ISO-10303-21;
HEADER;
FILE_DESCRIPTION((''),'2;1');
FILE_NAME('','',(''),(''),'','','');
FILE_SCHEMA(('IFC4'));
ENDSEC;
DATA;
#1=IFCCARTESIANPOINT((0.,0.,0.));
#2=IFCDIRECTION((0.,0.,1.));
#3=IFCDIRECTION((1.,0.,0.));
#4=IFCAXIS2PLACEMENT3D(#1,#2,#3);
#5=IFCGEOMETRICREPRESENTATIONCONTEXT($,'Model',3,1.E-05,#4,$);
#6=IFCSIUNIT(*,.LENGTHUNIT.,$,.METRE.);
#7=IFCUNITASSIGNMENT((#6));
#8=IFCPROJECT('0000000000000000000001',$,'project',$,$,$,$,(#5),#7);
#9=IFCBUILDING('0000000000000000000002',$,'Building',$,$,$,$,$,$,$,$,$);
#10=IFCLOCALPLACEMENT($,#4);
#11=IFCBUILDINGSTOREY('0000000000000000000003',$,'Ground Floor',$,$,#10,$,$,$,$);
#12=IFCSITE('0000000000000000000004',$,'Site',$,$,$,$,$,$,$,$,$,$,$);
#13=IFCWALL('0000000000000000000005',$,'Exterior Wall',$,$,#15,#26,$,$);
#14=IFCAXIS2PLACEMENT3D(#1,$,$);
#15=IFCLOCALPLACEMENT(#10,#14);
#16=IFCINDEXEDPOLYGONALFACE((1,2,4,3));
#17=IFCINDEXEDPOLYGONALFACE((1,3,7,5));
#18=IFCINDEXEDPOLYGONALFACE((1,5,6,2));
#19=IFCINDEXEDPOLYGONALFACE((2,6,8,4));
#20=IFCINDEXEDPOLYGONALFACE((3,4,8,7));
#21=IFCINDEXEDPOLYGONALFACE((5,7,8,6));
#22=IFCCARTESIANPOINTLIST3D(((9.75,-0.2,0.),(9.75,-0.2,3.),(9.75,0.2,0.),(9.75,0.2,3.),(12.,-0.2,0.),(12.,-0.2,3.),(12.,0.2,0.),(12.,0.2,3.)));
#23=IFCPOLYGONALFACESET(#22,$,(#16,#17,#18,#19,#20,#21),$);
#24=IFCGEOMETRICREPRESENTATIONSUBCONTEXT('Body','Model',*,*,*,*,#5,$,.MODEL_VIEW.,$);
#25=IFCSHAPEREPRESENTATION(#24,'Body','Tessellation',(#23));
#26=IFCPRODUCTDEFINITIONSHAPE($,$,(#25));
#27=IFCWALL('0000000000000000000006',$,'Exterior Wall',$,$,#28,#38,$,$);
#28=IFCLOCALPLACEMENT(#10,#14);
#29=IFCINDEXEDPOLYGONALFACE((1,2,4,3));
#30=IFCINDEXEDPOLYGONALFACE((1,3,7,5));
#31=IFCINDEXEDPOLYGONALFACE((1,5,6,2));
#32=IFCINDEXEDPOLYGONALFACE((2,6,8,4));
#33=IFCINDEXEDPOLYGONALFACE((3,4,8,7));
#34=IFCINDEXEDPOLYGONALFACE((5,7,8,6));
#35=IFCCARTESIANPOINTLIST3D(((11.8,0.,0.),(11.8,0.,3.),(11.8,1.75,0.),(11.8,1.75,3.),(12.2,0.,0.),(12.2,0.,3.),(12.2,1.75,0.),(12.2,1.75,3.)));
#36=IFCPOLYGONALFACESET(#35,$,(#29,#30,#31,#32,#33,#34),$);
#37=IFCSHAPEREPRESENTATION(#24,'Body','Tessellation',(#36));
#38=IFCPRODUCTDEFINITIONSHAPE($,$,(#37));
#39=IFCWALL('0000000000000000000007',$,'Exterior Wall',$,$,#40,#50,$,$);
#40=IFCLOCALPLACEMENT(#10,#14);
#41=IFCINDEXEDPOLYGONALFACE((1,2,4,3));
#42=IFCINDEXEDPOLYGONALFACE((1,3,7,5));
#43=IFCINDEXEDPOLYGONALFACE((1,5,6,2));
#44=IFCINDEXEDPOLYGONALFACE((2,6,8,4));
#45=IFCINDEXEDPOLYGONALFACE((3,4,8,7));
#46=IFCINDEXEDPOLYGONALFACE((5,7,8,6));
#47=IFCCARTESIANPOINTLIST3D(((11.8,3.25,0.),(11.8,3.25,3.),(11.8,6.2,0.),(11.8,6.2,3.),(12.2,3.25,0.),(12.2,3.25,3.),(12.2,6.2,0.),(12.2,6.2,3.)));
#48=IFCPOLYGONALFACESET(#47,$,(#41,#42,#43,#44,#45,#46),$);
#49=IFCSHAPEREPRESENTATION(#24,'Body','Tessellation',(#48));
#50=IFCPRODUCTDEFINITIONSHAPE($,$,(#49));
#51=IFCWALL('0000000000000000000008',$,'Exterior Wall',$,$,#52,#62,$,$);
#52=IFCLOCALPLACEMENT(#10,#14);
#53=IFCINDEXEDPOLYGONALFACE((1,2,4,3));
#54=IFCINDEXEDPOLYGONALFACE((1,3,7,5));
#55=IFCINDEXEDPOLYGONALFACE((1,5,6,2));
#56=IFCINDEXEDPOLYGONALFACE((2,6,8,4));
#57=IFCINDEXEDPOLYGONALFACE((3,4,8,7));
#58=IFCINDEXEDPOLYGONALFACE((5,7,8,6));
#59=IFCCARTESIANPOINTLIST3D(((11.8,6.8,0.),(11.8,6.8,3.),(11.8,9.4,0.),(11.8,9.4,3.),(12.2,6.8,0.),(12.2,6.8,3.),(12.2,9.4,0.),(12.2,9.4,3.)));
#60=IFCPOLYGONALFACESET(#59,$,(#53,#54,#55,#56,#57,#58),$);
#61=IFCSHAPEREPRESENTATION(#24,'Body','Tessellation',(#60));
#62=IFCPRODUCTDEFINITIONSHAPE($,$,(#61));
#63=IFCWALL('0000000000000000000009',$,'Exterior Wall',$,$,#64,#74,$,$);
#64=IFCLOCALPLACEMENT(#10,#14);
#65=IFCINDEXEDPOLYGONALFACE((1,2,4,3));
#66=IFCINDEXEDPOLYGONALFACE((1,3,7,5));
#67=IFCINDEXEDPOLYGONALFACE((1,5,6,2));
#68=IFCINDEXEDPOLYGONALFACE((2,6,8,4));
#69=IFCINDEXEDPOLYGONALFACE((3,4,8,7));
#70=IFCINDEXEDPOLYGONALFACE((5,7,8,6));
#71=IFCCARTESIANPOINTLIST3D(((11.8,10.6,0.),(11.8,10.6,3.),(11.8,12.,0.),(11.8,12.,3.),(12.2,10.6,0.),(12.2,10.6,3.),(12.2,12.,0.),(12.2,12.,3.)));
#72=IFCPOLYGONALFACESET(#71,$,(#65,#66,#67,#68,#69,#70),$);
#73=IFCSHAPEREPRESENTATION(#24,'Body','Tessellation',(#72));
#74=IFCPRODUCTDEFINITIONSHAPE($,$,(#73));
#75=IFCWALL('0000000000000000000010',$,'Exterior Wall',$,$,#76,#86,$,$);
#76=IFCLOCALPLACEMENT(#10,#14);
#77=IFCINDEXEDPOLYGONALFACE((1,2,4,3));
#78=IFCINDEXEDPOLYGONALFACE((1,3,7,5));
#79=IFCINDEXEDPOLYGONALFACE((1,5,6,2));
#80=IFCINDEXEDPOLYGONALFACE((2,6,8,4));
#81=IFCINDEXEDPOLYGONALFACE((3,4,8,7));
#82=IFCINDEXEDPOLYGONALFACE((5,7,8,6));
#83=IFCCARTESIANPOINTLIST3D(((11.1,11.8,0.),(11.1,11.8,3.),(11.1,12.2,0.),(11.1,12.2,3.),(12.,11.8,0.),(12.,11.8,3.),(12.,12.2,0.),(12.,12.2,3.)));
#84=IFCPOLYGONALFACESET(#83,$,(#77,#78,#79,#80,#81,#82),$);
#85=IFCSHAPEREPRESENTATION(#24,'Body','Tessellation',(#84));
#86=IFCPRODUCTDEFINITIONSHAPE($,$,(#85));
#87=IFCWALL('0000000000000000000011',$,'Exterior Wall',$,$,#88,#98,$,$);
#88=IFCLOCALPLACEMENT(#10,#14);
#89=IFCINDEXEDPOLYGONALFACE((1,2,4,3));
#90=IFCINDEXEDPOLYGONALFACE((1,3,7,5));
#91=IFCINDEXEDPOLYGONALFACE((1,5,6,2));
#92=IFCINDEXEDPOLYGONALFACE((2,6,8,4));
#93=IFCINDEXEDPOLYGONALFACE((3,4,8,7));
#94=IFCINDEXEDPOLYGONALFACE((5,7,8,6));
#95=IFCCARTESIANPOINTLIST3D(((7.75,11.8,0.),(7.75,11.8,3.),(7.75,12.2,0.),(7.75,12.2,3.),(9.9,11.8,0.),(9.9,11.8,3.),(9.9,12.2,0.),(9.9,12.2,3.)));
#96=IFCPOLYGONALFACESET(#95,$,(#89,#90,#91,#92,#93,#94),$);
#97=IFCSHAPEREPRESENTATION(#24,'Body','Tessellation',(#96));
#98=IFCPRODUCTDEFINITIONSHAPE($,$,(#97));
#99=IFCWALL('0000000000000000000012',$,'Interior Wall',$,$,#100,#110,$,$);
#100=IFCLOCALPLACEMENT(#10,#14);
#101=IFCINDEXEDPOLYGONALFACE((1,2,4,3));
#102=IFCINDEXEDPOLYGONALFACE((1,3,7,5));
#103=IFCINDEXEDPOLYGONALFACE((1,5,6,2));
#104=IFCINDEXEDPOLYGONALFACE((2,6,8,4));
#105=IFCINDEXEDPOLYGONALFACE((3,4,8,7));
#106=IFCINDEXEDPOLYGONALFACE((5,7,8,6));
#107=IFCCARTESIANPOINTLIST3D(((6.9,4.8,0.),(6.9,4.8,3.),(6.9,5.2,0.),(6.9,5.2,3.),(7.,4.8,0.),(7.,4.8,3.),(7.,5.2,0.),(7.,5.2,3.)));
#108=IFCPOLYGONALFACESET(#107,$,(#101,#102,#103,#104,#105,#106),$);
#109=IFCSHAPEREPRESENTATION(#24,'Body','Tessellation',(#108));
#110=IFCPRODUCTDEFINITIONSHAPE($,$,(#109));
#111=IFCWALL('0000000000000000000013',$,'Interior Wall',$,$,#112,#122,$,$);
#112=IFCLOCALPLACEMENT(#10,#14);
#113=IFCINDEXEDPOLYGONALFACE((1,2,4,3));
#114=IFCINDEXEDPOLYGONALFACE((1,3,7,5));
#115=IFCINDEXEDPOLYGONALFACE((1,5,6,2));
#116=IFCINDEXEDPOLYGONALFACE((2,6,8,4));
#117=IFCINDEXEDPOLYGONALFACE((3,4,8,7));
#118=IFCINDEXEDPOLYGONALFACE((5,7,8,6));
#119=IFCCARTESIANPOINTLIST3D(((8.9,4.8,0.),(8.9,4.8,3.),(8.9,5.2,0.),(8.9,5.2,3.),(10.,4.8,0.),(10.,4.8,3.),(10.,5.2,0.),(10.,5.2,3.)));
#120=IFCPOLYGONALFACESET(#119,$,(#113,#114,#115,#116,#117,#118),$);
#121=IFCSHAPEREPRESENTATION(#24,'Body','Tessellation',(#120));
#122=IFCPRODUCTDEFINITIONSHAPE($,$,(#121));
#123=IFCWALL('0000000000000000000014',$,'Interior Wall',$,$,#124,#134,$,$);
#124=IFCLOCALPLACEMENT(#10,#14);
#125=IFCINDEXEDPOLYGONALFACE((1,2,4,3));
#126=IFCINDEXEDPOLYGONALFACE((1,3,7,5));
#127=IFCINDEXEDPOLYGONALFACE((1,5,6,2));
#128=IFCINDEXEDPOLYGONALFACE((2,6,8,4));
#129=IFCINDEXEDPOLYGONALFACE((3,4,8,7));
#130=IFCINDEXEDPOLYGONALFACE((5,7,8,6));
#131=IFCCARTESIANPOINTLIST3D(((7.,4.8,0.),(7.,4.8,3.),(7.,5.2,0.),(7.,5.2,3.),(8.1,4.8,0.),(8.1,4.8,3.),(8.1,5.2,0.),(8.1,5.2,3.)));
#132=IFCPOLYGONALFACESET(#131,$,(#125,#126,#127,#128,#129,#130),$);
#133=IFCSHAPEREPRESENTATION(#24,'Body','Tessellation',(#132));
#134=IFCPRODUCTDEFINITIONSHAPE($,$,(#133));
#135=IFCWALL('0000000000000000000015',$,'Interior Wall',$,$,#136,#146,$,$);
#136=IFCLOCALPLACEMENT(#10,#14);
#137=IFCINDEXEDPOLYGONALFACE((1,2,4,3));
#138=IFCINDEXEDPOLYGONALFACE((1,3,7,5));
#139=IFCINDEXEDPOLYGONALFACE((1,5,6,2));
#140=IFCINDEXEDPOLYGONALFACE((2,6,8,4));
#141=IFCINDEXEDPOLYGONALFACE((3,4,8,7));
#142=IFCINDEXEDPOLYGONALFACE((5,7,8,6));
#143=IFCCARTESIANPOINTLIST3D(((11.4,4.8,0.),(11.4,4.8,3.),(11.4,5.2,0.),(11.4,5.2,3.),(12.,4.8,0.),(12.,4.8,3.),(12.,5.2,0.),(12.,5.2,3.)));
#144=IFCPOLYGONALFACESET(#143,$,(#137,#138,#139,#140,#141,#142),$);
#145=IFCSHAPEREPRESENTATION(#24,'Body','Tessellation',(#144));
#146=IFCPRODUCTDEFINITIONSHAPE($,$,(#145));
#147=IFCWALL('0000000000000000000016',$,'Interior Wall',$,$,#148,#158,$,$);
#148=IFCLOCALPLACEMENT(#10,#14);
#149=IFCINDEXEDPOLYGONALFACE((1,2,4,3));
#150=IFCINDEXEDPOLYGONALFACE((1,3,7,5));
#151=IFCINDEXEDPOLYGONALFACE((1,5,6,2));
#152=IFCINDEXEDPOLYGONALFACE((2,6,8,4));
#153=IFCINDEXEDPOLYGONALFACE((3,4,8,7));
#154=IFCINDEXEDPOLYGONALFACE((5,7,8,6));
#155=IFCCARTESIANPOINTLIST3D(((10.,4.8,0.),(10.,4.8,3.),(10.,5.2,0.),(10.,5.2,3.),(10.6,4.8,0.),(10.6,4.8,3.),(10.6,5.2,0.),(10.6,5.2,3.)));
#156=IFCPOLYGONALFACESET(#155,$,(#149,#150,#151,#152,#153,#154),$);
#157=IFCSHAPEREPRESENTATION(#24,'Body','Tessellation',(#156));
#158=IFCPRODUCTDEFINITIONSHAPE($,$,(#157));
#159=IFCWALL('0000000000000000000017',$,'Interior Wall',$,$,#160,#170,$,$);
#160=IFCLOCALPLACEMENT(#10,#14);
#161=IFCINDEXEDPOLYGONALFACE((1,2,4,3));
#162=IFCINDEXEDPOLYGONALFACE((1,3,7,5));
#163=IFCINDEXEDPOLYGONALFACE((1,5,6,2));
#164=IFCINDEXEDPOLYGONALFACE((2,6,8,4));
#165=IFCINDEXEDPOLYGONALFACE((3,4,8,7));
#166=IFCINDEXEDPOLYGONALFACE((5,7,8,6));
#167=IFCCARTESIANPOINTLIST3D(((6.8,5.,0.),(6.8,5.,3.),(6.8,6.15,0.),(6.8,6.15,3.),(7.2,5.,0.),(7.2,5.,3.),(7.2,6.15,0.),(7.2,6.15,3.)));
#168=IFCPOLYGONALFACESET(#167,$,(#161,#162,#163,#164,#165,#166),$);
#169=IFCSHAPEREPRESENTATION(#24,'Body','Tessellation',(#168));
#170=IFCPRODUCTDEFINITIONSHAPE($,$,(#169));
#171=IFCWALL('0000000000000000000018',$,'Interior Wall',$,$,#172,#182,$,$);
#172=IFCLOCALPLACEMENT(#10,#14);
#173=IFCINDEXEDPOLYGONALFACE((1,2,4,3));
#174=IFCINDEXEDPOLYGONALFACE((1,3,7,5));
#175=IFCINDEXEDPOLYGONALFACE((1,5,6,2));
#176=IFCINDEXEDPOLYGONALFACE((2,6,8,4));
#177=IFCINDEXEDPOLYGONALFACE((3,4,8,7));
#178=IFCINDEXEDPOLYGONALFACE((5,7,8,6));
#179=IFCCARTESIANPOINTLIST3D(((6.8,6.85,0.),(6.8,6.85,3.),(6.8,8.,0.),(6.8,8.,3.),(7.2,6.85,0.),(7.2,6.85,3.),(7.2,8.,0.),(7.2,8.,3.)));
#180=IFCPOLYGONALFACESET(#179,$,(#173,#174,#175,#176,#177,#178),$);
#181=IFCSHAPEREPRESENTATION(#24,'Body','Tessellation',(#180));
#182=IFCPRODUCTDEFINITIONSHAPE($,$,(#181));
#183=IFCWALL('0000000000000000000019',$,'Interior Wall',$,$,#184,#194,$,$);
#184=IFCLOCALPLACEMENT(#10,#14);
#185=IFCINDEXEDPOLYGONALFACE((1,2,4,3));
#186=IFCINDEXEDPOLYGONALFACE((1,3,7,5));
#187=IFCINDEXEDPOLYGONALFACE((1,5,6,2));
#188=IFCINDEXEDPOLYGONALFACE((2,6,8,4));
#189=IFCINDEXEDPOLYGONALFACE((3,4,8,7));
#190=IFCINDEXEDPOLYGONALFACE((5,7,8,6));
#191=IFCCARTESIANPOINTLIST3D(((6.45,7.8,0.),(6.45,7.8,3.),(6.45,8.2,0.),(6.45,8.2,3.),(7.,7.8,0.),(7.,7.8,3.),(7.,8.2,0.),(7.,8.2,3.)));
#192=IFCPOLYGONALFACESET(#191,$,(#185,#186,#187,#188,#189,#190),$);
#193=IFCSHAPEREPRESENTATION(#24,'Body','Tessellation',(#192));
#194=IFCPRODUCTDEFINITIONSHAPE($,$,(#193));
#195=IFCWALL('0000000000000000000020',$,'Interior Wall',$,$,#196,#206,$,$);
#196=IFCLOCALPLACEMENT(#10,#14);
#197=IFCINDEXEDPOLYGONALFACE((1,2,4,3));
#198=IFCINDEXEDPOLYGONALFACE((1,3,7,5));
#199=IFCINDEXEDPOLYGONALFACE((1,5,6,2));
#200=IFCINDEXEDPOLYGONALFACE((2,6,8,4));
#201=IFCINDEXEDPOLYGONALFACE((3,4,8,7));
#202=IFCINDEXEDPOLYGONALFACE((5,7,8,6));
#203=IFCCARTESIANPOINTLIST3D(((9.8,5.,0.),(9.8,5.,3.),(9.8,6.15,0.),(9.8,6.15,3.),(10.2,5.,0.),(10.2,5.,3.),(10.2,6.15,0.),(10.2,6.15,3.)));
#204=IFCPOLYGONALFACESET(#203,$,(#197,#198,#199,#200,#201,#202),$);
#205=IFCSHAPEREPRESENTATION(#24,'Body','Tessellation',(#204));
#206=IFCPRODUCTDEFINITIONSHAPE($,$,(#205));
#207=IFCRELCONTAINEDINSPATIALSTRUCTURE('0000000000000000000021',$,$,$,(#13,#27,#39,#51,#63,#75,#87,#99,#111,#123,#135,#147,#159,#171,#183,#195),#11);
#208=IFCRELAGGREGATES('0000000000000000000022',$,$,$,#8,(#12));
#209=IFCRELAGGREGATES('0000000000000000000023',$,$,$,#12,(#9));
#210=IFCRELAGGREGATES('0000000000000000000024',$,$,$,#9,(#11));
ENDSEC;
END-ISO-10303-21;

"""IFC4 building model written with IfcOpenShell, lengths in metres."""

from ifc_helpers import new_model, si_unit, frame, origin_with_axes, place, context, subcontext, project, spatial, indexed_curve, outline, extrude, element, save


model = new_model("IFC4")

# Units and contexts
model_context = context("Model", 3, precision=1e-05, world=origin_with_axes())
body_context = subcontext(model_context, "Body", "Model", "MODEL_VIEW")
ifc_project = project(units=[si_unit("LENGTHUNIT", "METRE")], contexts=[model_context])

# Site, building, storey
site = spatial("IfcSite", under=ifc_project, Name="Site")
building = spatial("IfcBuilding", under=site, Name="Building")
storey_placement = place(None, origin_with_axes())
storey = spatial("IfcBuildingStorey", under=building, at=storey_placement, Name="Ground Floor")

# Walls
wall_1_placement = place(storey_placement, frame((9.75, 0.0, 0.0), z_axis=(0.0, 0.0, 1.0), x_axis=(1.0, 0.0, 0.0)))
element("IfcWall", 1, at=wall_1_placement, inside=storey, Name="Exterior Wall", context=body_context, shape_type="SweptSolid", body=[
    extrude(outline(indexed_curve([(0.0, 0.0), (0.0, 0.4), (2.25, 0.4), (2.25, 0.0), (0.0, 0.0)], self_intersect=False)), frame((0.0, -0.2, 0.0), z_axis=(0.0, 0.0, 1.0), x_axis=(1.0, 0.0, 0.0)), (0.0, 0.0, 1.0), 3.0),
])
wall_2_placement = place(storey_placement, frame((12.0, 0.0, 0.0), z_axis=(0.0, 0.0, 1.0), x_axis=(0.0, 1.0, 0.0)))
element("IfcWall", 2, at=wall_2_placement, inside=storey, Name="Exterior Wall", context=body_context, shape_type="SweptSolid", body=[
    extrude(outline(indexed_curve([(0.0, 0.0), (0.0, 0.4), (1.75, 0.4), (1.75, 0.0), (0.0, 0.0)], self_intersect=False)), frame((0.0, -0.2, 0.0), z_axis=(0.0, 0.0, 1.0), x_axis=(1.0, 0.0, 0.0)), (0.0, 0.0, 1.0), 3.0),
])
wall_3_placement = place(storey_placement, frame((12.0, 3.25, 0.0), z_axis=(0.0, 0.0, 1.0), x_axis=(0.0, 1.0, 0.0)))
element("IfcWall", 3, at=wall_3_placement, inside=storey, Name="Exterior Wall", context=body_context, shape_type="SweptSolid", body=[
    extrude(outline(indexed_curve([(0.0, 0.0), (0.0, 0.4), (2.95, 0.4), (2.95, 0.0), (0.0, 0.0)], self_intersect=False)), frame((0.0, -0.2, 0.0), z_axis=(0.0, 0.0, 1.0), x_axis=(1.0, 0.0, 0.0)), (0.0, 0.0, 1.0), 3.0),
])
wall_4_placement = place(storey_placement, frame((12.0, 6.8, 0.0), z_axis=(0.0, 0.0, 1.0), x_axis=(0.0, 1.0, 0.0)))
element("IfcWall", 4, at=wall_4_placement, inside=storey, Name="Exterior Wall", context=body_context, shape_type="SweptSolid", body=[
    extrude(outline(indexed_curve([(0.0, 0.0), (0.0, 0.4), (2.6, 0.4), (2.6, 0.0), (0.0, 0.0)], self_intersect=False)), frame((0.0, -0.2, 0.0), z_axis=(0.0, 0.0, 1.0), x_axis=(1.0, 0.0, 0.0)), (0.0, 0.0, 1.0), 3.0),
])
wall_5_placement = place(storey_placement, frame((12.0, 10.6, 0.0), z_axis=(0.0, 0.0, 1.0), x_axis=(0.0, 1.0, 0.0)))
element("IfcWall", 5, at=wall_5_placement, inside=storey, Name="Exterior Wall", context=body_context, shape_type="SweptSolid", body=[
    extrude(outline(indexed_curve([(0.0, 0.0), (0.0, 0.4), (1.4, 0.4), (1.4, 0.0), (0.0, 0.0)], self_intersect=False)), frame((0.0, -0.2, 0.0), z_axis=(0.0, 0.0, 1.0), x_axis=(1.0, 0.0, 0.0)), (0.0, 0.0, 1.0), 3.0),
])
wall_6_placement = place(storey_placement, frame((12.0, 12.0, 0.0), z_axis=(0.0, 0.0, 1.0), x_axis=(-1.0, 0.0, 0.0)))
element("IfcWall", 6, at=wall_6_placement, inside=storey, Name="Exterior Wall", context=body_context, shape_type="SweptSolid", body=[
    extrude(outline(indexed_curve([(0.0, 0.0), (0.0, 0.4), (0.9, 0.4), (0.9, 0.0), (0.0, 0.0)], self_intersect=False)), frame((0.0, -0.2, 0.0), z_axis=(0.0, 0.0, 1.0), x_axis=(1.0, 0.0, 0.0)), (0.0, 0.0, 1.0), 3.0),
])
wall_7_placement = place(storey_placement, frame((9.9, 12.0, 0.0), z_axis=(0.0, 0.0, 1.0), x_axis=(-1.0, 0.0, 0.0)))
element("IfcWall", 7, at=wall_7_placement, inside=storey, Name="Exterior Wall", context=body_context, shape_type="SweptSolid", body=[
    extrude(outline(indexed_curve([(0.0, 0.0), (0.0, 0.4), (2.15, 0.4), (2.15, 0.0), (0.0, 0.0)], self_intersect=False)), frame((0.0, -0.2, 0.0), z_axis=(0.0, 0.0, 1.0), x_axis=(1.0, 0.0, 0.0)), (0.0, 0.0, 1.0), 3.0),
])
wall_8_placement = place(storey_placement, frame((7.0, 5.0, 0.0), z_axis=(0.0, 0.0, 1.0), x_axis=(-1.0, 0.0, 0.0)))
element("IfcWall", 8, at=wall_8_placement, inside=storey, Name="Interior Wall", context=body_context, shape_type="SweptSolid", body=[
    extrude(outline(indexed_curve([(0.0, 0.0), (0.0, 0.4), (0.1, 0.4), (0.1, 0.0), (0.0, 0.0)], self_intersect=False)), frame((0.0, -0.2, 0.0), z_axis=(0.0, 0.0, 1.0), x_axis=(1.0, 0.0, 0.0)), (0.0, 0.0, 1.0), 3.0),
])
for number, where, z_axis, x_axis, name in (
    (9, (10.0, 5.0, 0.0), (0.0, 0.0, 1.0), (-1.0, 0.0, 0.0), "Interior Wall"),
    (10, (8.1, 5.0, 0.0), (0.0, 0.0, 1.0), (-1.0, 0.0, 0.0), "Interior Wall"),
):
    element("IfcWall", number, at=place(storey_placement, frame(where, z_axis=z_axis, x_axis=x_axis)), inside=storey, Name=name, context=body_context, shape_type="SweptSolid", body=[
        extrude(outline(indexed_curve([(0.0, 0.0), (0.0, 0.4), (1.1, 0.4), (1.1, 0.0), (0.0, 0.0)], self_intersect=False)), frame((0.0, -0.2, 0.0), z_axis=(0.0, 0.0, 1.0), x_axis=(1.0, 0.0, 0.0)), (0.0, 0.0, 1.0), 3.0),
    ])
for number, where, z_axis, x_axis, name in (
    (11, (12.0, 5.0, 0.0), (0.0, 0.0, 1.0), (-1.0, 0.0, 0.0), "Interior Wall"),
    (12, (10.6, 5.0, 0.0), (0.0, 0.0, 1.0), (-1.0, 0.0, 0.0), "Interior Wall"),
):
    element("IfcWall", number, at=place(storey_placement, frame(where, z_axis=z_axis, x_axis=x_axis)), inside=storey, Name=name, context=body_context, shape_type="SweptSolid", body=[
        extrude(outline(indexed_curve([(0.0, 0.0), (0.0, 0.4), (0.6, 0.4), (0.6, 0.0), (0.0, 0.0)], self_intersect=False)), frame((0.0, -0.2, 0.0), z_axis=(0.0, 0.0, 1.0), x_axis=(1.0, 0.0, 0.0)), (0.0, 0.0, 1.0), 3.0),
    ])
for number, where, z_axis, x_axis, name in (
    (13, (7.0, 5.0, 0.0), (0.0, 0.0, 1.0), (0.0, 1.0, 0.0), "Interior Wall"),
    (14, (7.0, 6.85, 0.0), (0.0, 0.0, 1.0), (0.0, 1.0, 0.0), "Interior Wall"),
):
    element("IfcWall", number, at=place(storey_placement, frame(where, z_axis=z_axis, x_axis=x_axis)), inside=storey, Name=name, context=body_context, shape_type="SweptSolid", body=[
        extrude(outline(indexed_curve([(0.0, 0.0), (0.0, 0.4), (1.15, 0.4), (1.15, 0.0), (0.0, 0.0)], self_intersect=False)), frame((0.0, -0.2, 0.0), z_axis=(0.0, 0.0, 1.0), x_axis=(1.0, 0.0, 0.0)), (0.0, 0.0, 1.0), 3.0),
    ])
wall_9_placement = place(storey_placement, frame((7.0, 8.0, 0.0), z_axis=(0.0, 0.0, 1.0), x_axis=(-1.0, 0.0, 0.0)))
element("IfcWall", 15, at=wall_9_placement, inside=storey, Name="Interior Wall", context=body_context, shape_type="SweptSolid", body=[
    extrude(outline(indexed_curve([(0.0, 0.0), (0.0, 0.4), (0.55, 0.4), (0.55, 0.0), (0.0, 0.0)], self_intersect=False)), frame((0.0, -0.2, 0.0), z_axis=(0.0, 0.0, 1.0), x_axis=(1.0, 0.0, 0.0)), (0.0, 0.0, 1.0), 3.0),
])
for number, where, z_axis, x_axis, name in (
    (16, (10.0, 5.0, 0.0), (0.0, 0.0, 1.0), (0.0, 1.0, 0.0), "Interior Wall"),
):
    element("IfcWall", number, at=place(storey_placement, frame(where, z_axis=z_axis, x_axis=x_axis)), inside=storey, Name=name, context=body_context, shape_type="SweptSolid", body=[
        extrude(outline(indexed_curve([(0.0, 0.0), (0.0, 0.4), (1.15, 0.4), (1.15, 0.0), (0.0, 0.0)], self_intersect=False)), frame((0.0, -0.2, 0.0), z_axis=(0.0, 0.0, 1.0), x_axis=(1.0, 0.0, 0.0)), (0.0, 0.0, 1.0), 3.0),
    ])

save(model, "model.ifc")
